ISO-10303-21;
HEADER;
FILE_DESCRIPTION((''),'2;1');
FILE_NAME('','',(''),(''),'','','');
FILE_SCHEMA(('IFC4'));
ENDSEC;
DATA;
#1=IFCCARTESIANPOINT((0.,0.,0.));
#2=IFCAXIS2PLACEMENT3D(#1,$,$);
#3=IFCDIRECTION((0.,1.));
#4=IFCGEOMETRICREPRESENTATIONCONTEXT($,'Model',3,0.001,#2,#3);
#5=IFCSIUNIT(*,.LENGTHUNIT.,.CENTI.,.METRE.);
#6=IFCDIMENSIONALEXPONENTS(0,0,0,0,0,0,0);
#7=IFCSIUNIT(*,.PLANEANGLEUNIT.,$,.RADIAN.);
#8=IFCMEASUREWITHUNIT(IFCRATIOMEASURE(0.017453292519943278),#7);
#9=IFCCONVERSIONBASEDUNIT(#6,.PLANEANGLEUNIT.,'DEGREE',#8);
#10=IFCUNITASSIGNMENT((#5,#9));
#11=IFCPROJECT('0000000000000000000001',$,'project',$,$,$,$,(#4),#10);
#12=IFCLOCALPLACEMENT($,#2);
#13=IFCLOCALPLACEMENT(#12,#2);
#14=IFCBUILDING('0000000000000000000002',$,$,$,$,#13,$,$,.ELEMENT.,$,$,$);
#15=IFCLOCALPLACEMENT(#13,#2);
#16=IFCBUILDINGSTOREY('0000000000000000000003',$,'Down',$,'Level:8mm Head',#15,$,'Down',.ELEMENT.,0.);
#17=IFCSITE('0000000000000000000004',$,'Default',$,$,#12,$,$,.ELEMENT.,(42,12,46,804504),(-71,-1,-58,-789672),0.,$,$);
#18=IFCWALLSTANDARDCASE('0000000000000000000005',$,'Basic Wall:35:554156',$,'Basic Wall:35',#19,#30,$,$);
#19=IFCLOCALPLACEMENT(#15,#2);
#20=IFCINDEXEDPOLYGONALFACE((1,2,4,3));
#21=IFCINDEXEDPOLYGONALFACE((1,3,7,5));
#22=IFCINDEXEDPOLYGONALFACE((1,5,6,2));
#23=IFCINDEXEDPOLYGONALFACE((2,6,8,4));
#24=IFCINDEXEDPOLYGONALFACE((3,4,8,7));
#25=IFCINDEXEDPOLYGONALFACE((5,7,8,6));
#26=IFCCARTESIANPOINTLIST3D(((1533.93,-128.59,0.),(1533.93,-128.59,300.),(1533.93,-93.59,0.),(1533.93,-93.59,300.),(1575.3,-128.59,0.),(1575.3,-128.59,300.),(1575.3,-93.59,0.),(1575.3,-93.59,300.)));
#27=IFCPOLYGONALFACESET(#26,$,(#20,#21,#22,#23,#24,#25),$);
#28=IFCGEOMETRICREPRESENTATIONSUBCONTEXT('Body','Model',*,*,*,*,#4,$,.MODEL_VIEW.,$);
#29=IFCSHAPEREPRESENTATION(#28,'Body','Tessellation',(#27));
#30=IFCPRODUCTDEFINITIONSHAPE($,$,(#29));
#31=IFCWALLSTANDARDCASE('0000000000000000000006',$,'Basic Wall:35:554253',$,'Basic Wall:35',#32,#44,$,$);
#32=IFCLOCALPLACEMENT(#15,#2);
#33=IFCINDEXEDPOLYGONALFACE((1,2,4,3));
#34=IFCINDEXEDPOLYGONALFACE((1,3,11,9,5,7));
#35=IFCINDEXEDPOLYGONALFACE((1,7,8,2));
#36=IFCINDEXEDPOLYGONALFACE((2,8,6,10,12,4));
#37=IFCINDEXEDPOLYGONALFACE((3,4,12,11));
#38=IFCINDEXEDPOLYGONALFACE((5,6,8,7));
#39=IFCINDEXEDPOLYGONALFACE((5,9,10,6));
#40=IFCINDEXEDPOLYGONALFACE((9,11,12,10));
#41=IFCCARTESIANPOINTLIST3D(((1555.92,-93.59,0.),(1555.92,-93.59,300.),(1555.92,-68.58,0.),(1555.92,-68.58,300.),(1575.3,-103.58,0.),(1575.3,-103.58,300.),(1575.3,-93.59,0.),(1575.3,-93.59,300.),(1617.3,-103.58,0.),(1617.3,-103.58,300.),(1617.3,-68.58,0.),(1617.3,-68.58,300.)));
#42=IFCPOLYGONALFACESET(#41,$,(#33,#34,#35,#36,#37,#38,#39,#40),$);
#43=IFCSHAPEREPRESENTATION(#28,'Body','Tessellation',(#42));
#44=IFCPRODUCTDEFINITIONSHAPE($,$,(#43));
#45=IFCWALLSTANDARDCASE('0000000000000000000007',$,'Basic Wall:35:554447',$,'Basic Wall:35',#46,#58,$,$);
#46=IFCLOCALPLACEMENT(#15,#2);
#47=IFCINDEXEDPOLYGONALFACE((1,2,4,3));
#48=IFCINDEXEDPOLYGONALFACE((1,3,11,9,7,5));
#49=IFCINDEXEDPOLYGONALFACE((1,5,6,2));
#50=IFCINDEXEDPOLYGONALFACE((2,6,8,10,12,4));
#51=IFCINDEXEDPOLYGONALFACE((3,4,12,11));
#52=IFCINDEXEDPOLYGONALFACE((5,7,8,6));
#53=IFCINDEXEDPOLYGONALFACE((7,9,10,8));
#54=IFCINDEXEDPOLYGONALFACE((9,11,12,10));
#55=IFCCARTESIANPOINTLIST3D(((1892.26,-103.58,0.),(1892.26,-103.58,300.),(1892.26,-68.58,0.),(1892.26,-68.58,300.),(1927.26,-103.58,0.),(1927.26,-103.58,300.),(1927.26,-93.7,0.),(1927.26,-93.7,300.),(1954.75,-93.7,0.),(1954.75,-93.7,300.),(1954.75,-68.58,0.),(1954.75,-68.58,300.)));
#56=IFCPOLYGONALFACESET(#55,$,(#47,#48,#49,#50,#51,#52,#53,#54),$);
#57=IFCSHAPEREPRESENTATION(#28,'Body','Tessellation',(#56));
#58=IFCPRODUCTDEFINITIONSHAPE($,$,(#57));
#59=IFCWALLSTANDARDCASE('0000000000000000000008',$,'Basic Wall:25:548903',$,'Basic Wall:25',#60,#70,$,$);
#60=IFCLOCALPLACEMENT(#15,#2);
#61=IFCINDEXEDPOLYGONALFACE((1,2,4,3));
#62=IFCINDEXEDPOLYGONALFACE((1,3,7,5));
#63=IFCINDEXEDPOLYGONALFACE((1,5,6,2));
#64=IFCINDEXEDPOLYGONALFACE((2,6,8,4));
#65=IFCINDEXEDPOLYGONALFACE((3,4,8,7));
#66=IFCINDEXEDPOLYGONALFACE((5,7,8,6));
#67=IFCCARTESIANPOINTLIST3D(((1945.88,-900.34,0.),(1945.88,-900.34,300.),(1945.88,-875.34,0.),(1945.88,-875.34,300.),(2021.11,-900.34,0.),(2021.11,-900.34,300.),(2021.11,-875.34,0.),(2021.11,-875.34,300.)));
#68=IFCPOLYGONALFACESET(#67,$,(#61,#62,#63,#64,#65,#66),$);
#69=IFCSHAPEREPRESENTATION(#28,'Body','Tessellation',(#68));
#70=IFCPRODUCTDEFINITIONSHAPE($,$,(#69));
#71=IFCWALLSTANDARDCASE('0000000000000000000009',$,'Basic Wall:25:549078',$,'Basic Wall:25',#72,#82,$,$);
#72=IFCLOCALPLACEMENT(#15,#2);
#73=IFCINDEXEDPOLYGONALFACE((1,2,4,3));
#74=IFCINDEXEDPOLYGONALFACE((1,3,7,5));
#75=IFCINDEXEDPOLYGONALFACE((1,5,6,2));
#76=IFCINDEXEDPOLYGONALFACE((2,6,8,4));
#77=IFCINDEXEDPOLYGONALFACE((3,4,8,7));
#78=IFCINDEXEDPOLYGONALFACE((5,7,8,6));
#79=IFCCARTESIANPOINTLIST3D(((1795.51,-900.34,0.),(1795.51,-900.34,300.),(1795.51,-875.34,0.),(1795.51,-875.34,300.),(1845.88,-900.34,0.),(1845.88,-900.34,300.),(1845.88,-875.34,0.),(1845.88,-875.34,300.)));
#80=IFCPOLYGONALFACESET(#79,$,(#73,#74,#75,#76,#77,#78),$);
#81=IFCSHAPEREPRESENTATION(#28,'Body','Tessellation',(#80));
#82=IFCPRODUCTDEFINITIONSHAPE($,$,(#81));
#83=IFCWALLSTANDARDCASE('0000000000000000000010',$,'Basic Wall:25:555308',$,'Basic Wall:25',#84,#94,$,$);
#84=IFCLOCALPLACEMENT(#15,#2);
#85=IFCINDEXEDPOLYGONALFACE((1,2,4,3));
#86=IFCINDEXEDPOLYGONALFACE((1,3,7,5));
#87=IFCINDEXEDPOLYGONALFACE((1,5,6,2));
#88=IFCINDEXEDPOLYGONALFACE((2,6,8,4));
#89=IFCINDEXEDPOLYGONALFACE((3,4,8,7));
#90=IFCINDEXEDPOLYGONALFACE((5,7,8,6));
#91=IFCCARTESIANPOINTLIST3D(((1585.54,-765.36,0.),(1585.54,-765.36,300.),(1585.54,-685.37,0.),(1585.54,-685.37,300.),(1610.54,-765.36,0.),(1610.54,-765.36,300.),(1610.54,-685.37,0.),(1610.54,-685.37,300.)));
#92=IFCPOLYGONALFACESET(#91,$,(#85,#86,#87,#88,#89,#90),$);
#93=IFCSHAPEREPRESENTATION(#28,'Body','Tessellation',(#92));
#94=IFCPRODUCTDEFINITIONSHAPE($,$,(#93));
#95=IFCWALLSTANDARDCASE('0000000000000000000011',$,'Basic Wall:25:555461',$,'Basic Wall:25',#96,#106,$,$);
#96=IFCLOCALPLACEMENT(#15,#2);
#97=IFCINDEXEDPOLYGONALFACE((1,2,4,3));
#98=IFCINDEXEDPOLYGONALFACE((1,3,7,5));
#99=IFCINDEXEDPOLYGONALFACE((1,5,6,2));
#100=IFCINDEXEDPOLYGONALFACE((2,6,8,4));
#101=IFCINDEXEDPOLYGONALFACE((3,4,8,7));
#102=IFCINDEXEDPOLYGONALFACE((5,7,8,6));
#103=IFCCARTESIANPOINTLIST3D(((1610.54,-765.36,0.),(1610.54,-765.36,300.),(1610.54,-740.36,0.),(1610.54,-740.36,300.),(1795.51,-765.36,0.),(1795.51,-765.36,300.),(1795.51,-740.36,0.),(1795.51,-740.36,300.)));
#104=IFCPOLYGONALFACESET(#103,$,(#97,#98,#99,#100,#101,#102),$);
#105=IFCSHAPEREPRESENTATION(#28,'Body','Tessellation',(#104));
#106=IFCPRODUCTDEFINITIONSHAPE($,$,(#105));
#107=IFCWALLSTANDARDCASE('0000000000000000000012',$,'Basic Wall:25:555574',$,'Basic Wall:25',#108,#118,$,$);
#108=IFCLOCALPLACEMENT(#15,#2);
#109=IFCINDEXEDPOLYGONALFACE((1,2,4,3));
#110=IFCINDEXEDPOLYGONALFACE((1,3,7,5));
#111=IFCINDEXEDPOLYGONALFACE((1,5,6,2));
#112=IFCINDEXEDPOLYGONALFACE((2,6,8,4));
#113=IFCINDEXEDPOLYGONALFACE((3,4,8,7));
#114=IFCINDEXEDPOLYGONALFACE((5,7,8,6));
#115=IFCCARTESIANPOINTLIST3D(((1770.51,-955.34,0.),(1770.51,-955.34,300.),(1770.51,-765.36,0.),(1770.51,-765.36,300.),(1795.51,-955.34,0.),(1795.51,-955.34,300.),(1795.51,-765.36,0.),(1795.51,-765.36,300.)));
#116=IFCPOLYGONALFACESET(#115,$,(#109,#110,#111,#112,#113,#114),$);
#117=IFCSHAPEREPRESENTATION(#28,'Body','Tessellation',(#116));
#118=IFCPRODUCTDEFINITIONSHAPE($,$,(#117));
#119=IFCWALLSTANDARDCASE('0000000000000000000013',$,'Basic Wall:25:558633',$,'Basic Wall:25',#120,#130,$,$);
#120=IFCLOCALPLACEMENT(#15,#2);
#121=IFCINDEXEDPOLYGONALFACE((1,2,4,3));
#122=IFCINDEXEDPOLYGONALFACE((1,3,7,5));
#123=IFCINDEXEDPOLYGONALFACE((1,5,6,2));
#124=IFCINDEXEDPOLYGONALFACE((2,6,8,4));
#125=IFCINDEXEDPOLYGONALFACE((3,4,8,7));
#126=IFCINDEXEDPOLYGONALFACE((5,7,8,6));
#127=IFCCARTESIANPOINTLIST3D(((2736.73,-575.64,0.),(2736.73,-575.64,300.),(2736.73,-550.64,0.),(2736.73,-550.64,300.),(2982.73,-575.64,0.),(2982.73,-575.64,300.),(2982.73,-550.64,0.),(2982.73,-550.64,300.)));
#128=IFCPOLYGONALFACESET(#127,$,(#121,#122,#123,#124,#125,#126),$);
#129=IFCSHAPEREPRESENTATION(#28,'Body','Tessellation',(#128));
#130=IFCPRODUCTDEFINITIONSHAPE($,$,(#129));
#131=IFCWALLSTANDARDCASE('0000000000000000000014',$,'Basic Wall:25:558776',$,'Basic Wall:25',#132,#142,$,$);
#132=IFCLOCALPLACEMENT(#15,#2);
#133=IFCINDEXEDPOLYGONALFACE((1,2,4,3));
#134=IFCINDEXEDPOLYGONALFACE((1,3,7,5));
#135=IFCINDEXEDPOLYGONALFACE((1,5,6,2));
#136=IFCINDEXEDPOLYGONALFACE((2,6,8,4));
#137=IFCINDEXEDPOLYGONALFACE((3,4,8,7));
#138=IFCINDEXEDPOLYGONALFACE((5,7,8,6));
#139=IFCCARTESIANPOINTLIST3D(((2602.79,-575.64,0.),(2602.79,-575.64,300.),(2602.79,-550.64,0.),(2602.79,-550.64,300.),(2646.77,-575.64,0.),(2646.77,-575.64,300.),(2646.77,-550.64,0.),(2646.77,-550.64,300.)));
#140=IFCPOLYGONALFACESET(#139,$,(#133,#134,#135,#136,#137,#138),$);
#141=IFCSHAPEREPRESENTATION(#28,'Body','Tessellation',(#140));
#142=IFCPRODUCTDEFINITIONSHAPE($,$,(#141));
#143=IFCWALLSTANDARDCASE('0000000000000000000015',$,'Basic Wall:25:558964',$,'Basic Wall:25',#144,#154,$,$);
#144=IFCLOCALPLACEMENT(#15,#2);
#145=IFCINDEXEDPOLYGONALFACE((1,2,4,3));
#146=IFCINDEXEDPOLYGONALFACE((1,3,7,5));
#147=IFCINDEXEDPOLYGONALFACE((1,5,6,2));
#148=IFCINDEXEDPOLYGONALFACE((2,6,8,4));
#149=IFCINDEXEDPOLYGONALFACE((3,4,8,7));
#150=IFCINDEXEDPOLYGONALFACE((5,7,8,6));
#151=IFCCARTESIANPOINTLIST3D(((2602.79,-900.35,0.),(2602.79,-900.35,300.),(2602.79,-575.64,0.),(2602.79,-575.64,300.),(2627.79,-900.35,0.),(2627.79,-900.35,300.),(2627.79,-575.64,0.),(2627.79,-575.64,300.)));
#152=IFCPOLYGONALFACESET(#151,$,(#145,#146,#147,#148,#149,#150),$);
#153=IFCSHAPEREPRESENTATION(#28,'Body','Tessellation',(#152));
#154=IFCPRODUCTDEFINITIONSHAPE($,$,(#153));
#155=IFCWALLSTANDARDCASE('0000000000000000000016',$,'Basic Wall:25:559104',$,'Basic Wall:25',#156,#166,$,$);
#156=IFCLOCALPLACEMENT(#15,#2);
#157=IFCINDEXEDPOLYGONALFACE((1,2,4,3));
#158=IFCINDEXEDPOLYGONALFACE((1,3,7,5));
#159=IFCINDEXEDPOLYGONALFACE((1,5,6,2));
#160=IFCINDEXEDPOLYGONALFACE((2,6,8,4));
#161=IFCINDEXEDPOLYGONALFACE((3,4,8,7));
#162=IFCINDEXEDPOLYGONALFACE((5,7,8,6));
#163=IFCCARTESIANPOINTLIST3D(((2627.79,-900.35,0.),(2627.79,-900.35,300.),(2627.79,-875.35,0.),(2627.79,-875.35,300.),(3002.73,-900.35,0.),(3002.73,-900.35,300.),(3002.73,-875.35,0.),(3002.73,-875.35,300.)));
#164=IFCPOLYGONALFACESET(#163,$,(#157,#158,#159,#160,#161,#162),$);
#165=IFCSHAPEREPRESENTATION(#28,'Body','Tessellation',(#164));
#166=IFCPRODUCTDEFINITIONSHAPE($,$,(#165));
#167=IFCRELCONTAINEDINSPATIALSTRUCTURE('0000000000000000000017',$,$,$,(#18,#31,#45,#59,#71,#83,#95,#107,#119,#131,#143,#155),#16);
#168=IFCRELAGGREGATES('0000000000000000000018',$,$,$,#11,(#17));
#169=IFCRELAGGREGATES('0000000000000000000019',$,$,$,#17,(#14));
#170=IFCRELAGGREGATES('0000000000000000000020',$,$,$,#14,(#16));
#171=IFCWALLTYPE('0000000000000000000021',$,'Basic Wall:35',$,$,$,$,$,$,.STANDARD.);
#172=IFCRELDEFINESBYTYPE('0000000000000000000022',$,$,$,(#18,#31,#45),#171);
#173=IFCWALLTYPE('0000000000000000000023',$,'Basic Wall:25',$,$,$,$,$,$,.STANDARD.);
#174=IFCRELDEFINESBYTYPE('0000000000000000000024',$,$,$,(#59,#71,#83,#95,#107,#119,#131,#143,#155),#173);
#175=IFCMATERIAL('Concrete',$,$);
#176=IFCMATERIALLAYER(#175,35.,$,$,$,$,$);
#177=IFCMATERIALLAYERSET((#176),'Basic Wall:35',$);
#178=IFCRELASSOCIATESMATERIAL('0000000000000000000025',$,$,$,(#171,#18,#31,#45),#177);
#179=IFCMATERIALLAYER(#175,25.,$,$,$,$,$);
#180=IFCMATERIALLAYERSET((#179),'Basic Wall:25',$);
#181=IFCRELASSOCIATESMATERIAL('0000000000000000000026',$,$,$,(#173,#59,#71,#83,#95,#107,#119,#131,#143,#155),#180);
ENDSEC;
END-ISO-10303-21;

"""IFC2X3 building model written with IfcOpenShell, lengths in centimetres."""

from ifc_helpers import new_model, entity, si_unit, converted_unit, direction, frame, frame_2d, origin, place, context, subcontext, project, spatial, polyline, rectangle, extrude, clip, bounded_halfspace, material, layer, layer_set, layer_usage, type_object, element, save


model = new_model("IFC2X3")

# Units and contexts
model_context = context("Model", 3, precision=0.001, world=origin(), true_north=direction((0.0, 1.0)))
body_context = subcontext(model_context, "Body", "Model", "MODEL_VIEW")
ifc_project = project(units=[si_unit("LENGTHUNIT", "METRE", prefix="CENTI"), converted_unit("PLANEANGLEUNIT", "DEGREE", entity("IfcRatioMeasure", 0.017453292519943278), si_unit("PLANEANGLEUNIT", "RADIAN"), dimensions=[0, 0, 0, 0, 0, 0, 0])], contexts=[model_context])

# Site, building, storey
site_placement = place(None, origin())
site = spatial("IfcSite", under=ifc_project, at=site_placement, Name="Default", CompositionType="ELEMENT", RefLatitude=(42, 12, 46, 804504), RefLongitude=(-71, -1, -58, -789672), RefElevation=0.0)
building_placement = place(site_placement, origin())
building = spatial("IfcBuilding", under=site, at=building_placement, CompositionType="ELEMENT")
storey_placement = place(building_placement, origin())
storey = spatial("IfcBuildingStorey", under=building, at=storey_placement, Name="Down", ObjectType="Level:8mm Head", LongName="Down", CompositionType="ELEMENT", Elevation=0.0)

# Walls
ifc_material = material(Name="Concrete")
ifc_layer_1 = layer(ifc_material, 35.0)
ifc_layer_set_1 = layer_set([ifc_layer_1], Name="Basic Wall:35")
wall_type_1 = type_object("IfcWallType", Name="Basic Wall:35", PredefinedType="STANDARD", material=ifc_layer_set_1)
ifc_layer_usage_1 = layer_usage(ifc_layer_set_1, "AXIS2", "NEGATIVE", 17.5)
wall_1_placement = place(storey_placement, frame((1533.93, -111.09, 0.0)))
element("IfcWallStandardCase", 1, at=wall_1_placement, inside=storey, type_object=wall_type_1, material=ifc_layer_usage_1, Name="Basic Wall:35:554156", ObjectType="Basic Wall:35", context=body_context, shape_type="SweptSolid", body=[
    extrude(rectangle(XDim=41.37, YDim=35.0, at=frame_2d((20.68, 0.0), x_axis=(-1.0, 0.0))), origin(), (0.0, 0.0, 1.0), 300.0),
])
ifc_layer_usage_2 = layer_usage(ifc_layer_set_1, "AXIS2", "NEGATIVE", 17.5)
wall_2_placement = place(storey_placement, frame((1555.92, -86.08, 0.0)))
element("IfcWallStandardCase", 2, at=wall_2_placement, inside=storey, type_object=wall_type_1, material=ifc_layer_usage_2, Name="Basic Wall:35:554253", ObjectType="Basic Wall:35", context=body_context, shape_type="Clipping", body=[
    clip(clip(extrude(rectangle(XDim=61.37, YDim=35.0, at=frame_2d((30.69, 0.0), x_axis=(-1.0, 0.0))), origin(), (0.0, 0.0, 1.0), 300.0), bounded_halfspace(frame((19.37, -7.51, 0.0), z_axis=(0.0, 1.0, 0.0), x_axis=(-1.0, 0.0, 0.0)), True, frame((19.37, -7.51, 0.0), z_axis=(0.0, 1.0, 0.0), x_axis=(-1.0, 0.0, 0.0)), polyline([(0.0, 0.0), (19.37, 0.0), (19.37, 263.0), (19.37, 285.0), (19.37, 300.0), (0.0, 300.0), (0.0, 0.0)]))), bounded_halfspace(frame((19.37, -7.51, 300.0), z_axis=(-1.0, 0.0, 0.0), x_axis=(0.0, -1.0, 0.0)), False, frame((19.37, -7.51, 300.0), z_axis=(-1.0, 0.0, 0.0), x_axis=(0.0, -1.0, 0.0)), polyline([(0.0, 0.0), (0.0, -300.0), (9.99, -300.0), (9.99, 0.0), (0.0, 0.0)]))),
])
ifc_layer_usage_3 = layer_usage(ifc_layer_set_1, "AXIS2", "POSITIVE", -17.5)
wall_3_placement = place(storey_placement, frame((1954.75, -86.08, 0.0), z_axis=(0.0, 0.0, 1.0), x_axis=(-1.0, 0.0, 0.0)))
element("IfcWallStandardCase", 3, at=wall_3_placement, inside=storey, type_object=wall_type_1, material=ifc_layer_usage_3, Name="Basic Wall:35:554447", ObjectType="Basic Wall:35", context=body_context, shape_type="Clipping", body=[
    clip(clip(extrude(rectangle(XDim=62.5, YDim=35.0, at=frame_2d((31.25, 0.0), x_axis=(-1.0, 0.0))), origin(), (0.0, 0.0, 1.0), 300.0), bounded_halfspace(frame((27.5, 7.62, 300.0), z_axis=(0.0, -1.0, 0.0), x_axis=(1.0, 0.0, 0.0)), True, frame((27.5, 7.62, 300.0), z_axis=(0.0, -1.0, 0.0), x_axis=(1.0, 0.0, 0.0)), polyline([(0.0, 0.0), (-27.5, 0.0), (-27.5, -15.0), (-27.5, -37.0), (-27.5, -300.0), (0.0, -300.0), (0.0, 0.0)]))), bounded_halfspace(frame((27.5, 7.62, 0.0), z_axis=(-1.0, 0.0, 0.0), x_axis=(0.0, -1.0, 0.0)), False, frame((27.5, 7.62, 0.0), z_axis=(-1.0, 0.0, 0.0), x_axis=(0.0, -1.0, 0.0)), polyline([(0.0, 0.0), (0.0, 300.0), (-9.88, 300.0), (-9.88, 0.0), (0.0, 0.0)]))),
])
ifc_layer_2 = layer(ifc_material, 25.0)
ifc_layer_set_2 = layer_set([ifc_layer_2], Name="Basic Wall:25")
ifc_layer_usage_4 = layer_usage(ifc_layer_set_2, "AXIS2", "POSITIVE", -12.5)
wall_type_2 = type_object("IfcWallType", Name="Basic Wall:25", PredefinedType="STANDARD", material=ifc_layer_set_2)
wall_4_placement = place(storey_placement, frame((2021.11, -887.84, 0.0), z_axis=(0.0, 0.0, 1.0), x_axis=(-1.0, 0.0, 0.0)))
element("IfcWallStandardCase", 4, at=wall_4_placement, inside=storey, type_object=wall_type_2, material=ifc_layer_usage_4, Name="Basic Wall:25:548903", ObjectType="Basic Wall:25", context=body_context, shape_type="SweptSolid", body=[
    extrude(rectangle(XDim=75.23, YDim=25.0, at=frame_2d((37.61, 0.0), x_axis=(-1.0, 0.0))), origin(), (0.0, 0.0, 1.0), 300.0),
])
ifc_layer_usage_5 = layer_usage(ifc_layer_set_2, "AXIS2", "POSITIVE", -12.5)
wall_5_placement = place(storey_placement, frame((1845.88, -887.84, 0.0), z_axis=(0.0, 0.0, 1.0), x_axis=(-1.0, 0.0, 0.0)))
element("IfcWallStandardCase", 5, at=wall_5_placement, inside=storey, type_object=wall_type_2, material=ifc_layer_usage_5, Name="Basic Wall:25:549078", ObjectType="Basic Wall:25", context=body_context, shape_type="SweptSolid", body=[
    extrude(rectangle(XDim=50.37, YDim=25.0, at=frame_2d((25.18, 0.0), x_axis=(-1.0, 0.0))), origin(), (0.0, 0.0, 1.0), 300.0),
])
ifc_layer_usage_6 = layer_usage(ifc_layer_set_2, "AXIS2", "NEGATIVE", 12.5)
wall_6_placement = place(storey_placement, frame((1598.04, -685.37, 0.0), z_axis=(0.0, 0.0, 1.0), x_axis=(0.0, -1.0, 0.0)))
element("IfcWallStandardCase", 6, at=wall_6_placement, inside=storey, type_object=wall_type_2, material=ifc_layer_usage_6, Name="Basic Wall:25:555308", ObjectType="Basic Wall:25", context=body_context, shape_type="SweptSolid", body=[
    extrude(rectangle(XDim=79.99, YDim=25.0, at=frame_2d((39.99, 0.0), x_axis=(-1.0, 0.0))), origin(), (0.0, 0.0, 1.0), 300.0),
])
ifc_layer_usage_7 = layer_usage(ifc_layer_set_2, "AXIS2", "POSITIVE", -12.5)
wall_7_placement = place(storey_placement, frame((1610.54, -752.86, 0.0)))
element("IfcWallStandardCase", 7, at=wall_7_placement, inside=storey, type_object=wall_type_2, material=ifc_layer_usage_7, Name="Basic Wall:25:555461", ObjectType="Basic Wall:25", context=body_context, shape_type="SweptSolid", body=[
    extrude(rectangle(XDim=184.97, YDim=25.0, at=frame_2d((92.49, 0.0), x_axis=(-1.0, 0.0))), origin(), (0.0, 0.0, 1.0), 300.0),
])
ifc_layer_usage_8 = layer_usage(ifc_layer_set_2, "AXIS2", "NEGATIVE", 12.5)
wall_8_placement = place(storey_placement, frame((1783.01, -765.36, 0.0), z_axis=(0.0, 0.0, 1.0), x_axis=(0.0, -1.0, 0.0)))
element("IfcWallStandardCase", 8, at=wall_8_placement, inside=storey, type_object=wall_type_2, material=ifc_layer_usage_8, Name="Basic Wall:25:555574", ObjectType="Basic Wall:25", context=body_context, shape_type="SweptSolid", body=[
    extrude(rectangle(XDim=189.98, YDim=25.0, at=frame_2d((94.99, 0.0), x_axis=(-1.0, 0.0))), origin(), (0.0, 0.0, 1.0), 300.0),
])
ifc_layer_usage_9 = layer_usage(ifc_layer_set_2, "AXIS2", "POSITIVE", -12.5)
wall_9_placement = place(storey_placement, frame((2982.73, -563.14, 0.0), z_axis=(0.0, 0.0, 1.0), x_axis=(-1.0, 0.0, 0.0)))
element("IfcWallStandardCase", 9, at=wall_9_placement, inside=storey, type_object=wall_type_2, material=ifc_layer_usage_9, Name="Basic Wall:25:558633", ObjectType="Basic Wall:25", context=body_context, shape_type="SweptSolid", body=[
    extrude(rectangle(XDim=246.0, YDim=25.0, at=frame_2d((123.0, 0.0), x_axis=(-1.0, 0.0))), origin(), (0.0, 0.0, 1.0), 300.0),
])
ifc_layer_usage_10 = layer_usage(ifc_layer_set_2, "AXIS2", "POSITIVE", -12.5)
wall_10_placement = place(storey_placement, frame((2646.77, -563.14, 0.0), z_axis=(0.0, 0.0, 1.0), x_axis=(-1.0, 0.0, 0.0)))
element("IfcWallStandardCase", 10, at=wall_10_placement, inside=storey, type_object=wall_type_2, material=ifc_layer_usage_10, Name="Basic Wall:25:558776", ObjectType="Basic Wall:25", context=body_context, shape_type="SweptSolid", body=[
    extrude(rectangle(XDim=43.99, YDim=25.0, at=frame_2d((21.99, 0.0), x_axis=(-1.0, 0.0))), origin(), (0.0, 0.0, 1.0), 300.0),
])
ifc_layer_usage_11 = layer_usage(ifc_layer_set_2, "AXIS2", "POSITIVE", -12.5)
wall_11_placement = place(storey_placement, frame((2615.29, -575.64, 0.0), z_axis=(0.0, 0.0, 1.0), x_axis=(0.0, -1.0, 0.0)))
element("IfcWallStandardCase", 11, at=wall_11_placement, inside=storey, type_object=wall_type_2, material=ifc_layer_usage_11, Name="Basic Wall:25:558964", ObjectType="Basic Wall:25", context=body_context, shape_type="SweptSolid", body=[
    extrude(rectangle(XDim=324.71, YDim=25.0, at=frame_2d((162.36, 0.0), x_axis=(-1.0, 0.0))), origin(), (0.0, 0.0, 1.0), 300.0),
])
ifc_layer_usage_12 = layer_usage(ifc_layer_set_2, "AXIS2", "POSITIVE", -12.5)
wall_12_placement = place(storey_placement, frame((2627.79, -887.85, 0.0)))
element("IfcWallStandardCase", 12, at=wall_12_placement, inside=storey, type_object=wall_type_2, material=ifc_layer_usage_12, Name="Basic Wall:25:559104", ObjectType="Basic Wall:25", context=body_context, shape_type="SweptSolid", body=[
    extrude(rectangle(XDim=374.94, YDim=25.0, at=frame_2d((187.47, 0.0), x_axis=(-1.0, 0.0))), origin(), (0.0, 0.0, 1.0), 300.0),
])

save(model, "model.ifc")
